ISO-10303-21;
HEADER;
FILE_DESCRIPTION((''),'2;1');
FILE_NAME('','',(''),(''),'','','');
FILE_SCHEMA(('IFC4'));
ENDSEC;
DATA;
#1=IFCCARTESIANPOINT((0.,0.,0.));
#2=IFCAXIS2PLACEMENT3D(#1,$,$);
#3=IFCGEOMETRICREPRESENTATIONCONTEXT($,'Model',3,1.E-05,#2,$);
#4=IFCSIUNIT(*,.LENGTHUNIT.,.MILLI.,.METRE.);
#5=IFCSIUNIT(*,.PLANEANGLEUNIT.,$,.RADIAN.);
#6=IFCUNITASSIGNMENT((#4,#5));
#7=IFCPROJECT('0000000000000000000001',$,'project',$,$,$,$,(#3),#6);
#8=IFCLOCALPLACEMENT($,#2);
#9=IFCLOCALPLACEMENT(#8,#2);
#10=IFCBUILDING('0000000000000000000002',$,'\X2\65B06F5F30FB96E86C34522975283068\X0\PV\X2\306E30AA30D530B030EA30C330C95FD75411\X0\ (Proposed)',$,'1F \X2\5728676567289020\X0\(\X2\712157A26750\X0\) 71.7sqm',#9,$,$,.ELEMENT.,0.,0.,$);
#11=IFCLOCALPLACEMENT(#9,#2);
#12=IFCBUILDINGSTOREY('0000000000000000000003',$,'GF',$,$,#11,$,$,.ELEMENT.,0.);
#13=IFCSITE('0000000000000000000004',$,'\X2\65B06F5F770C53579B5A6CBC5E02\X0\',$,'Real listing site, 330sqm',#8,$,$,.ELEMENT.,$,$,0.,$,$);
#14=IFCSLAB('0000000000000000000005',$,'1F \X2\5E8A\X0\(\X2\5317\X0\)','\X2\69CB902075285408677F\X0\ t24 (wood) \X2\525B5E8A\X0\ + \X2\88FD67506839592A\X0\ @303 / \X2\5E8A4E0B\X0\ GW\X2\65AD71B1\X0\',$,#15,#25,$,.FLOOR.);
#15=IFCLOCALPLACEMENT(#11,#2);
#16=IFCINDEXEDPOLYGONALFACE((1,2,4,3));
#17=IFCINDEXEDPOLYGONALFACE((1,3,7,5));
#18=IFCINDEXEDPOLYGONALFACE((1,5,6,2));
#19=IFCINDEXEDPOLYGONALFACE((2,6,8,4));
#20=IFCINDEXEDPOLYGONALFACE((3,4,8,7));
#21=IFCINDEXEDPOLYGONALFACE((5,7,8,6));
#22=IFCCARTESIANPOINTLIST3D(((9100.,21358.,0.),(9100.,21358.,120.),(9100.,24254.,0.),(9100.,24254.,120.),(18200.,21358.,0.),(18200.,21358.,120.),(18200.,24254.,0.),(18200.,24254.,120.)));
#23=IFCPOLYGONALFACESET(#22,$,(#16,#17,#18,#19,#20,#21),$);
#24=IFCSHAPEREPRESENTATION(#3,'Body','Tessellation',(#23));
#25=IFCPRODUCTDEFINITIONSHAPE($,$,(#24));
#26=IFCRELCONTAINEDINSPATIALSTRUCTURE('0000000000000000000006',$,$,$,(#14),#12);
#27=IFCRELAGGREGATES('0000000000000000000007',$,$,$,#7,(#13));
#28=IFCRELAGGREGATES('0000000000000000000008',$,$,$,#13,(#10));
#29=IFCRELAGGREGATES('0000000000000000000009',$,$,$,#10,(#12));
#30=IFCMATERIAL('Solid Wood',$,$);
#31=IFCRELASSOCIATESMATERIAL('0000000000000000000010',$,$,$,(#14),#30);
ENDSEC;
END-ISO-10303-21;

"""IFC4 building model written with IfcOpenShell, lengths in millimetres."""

from ifc_helpers import new_model, si_unit, frame, frame_2d, origin, place, context, project, spatial, rectangle, extrude, material, element, save


model = new_model("IFC4")

# Units and contexts
model_context = context("Model", 3, precision=1e-05, world=origin())
ifc_project = project(units=[si_unit("LENGTHUNIT", "METRE", prefix="MILLI"), si_unit("PLANEANGLEUNIT", "RADIAN")], contexts=[model_context])

# Site, building, storey
site_placement = place(None, origin())
site = spatial("IfcSite", under=ifc_project, at=site_placement, Name="新潟県南魚沼市", ObjectType="Real listing site, 330sqm", CompositionType="ELEMENT", RefElevation=0.0)
building_placement = place(site_placement, origin())
building = spatial("IfcBuilding", under=site, at=building_placement, Name="新潟・雨水利用とPVのオフグリッド志向 (Proposed)", ObjectType="1F 在来木造(無垢材) 71.7sqm", CompositionType="ELEMENT", ElevationOfRefHeight=0.0, ElevationOfTerrain=0.0)
storey_placement = place(building_placement, origin())
storey = spatial("IfcBuildingStorey", under=building, at=storey_placement, Name="GF", CompositionType="ELEMENT", Elevation=0.0)

# Shared definitions
ifc_material_1 = material(Name="Solid Wood")

# Slab
slab_placement = place(storey_placement, frame((4550.0, 10679.0, 0.0)))
element("IfcSlab", 1, at=slab_placement, inside=storey, material=ifc_material_1, Name="1F 床(北)", Description="構造用合板 t24 (wood) 剛床 + 製材根太 @303 / 床下 GW断熱", PredefinedType="FLOOR", context=model_context, shape_type="SweptSolid", body=[
    extrude(rectangle(XDim=9100.0, YDim=2896.0, at=frame_2d((4550.0, 1448.0))), frame((4550.0, 10679.0, 0.0)), (0.0, 0.0, 1.0), 120.0),
])

save(model, "model.ifc")
